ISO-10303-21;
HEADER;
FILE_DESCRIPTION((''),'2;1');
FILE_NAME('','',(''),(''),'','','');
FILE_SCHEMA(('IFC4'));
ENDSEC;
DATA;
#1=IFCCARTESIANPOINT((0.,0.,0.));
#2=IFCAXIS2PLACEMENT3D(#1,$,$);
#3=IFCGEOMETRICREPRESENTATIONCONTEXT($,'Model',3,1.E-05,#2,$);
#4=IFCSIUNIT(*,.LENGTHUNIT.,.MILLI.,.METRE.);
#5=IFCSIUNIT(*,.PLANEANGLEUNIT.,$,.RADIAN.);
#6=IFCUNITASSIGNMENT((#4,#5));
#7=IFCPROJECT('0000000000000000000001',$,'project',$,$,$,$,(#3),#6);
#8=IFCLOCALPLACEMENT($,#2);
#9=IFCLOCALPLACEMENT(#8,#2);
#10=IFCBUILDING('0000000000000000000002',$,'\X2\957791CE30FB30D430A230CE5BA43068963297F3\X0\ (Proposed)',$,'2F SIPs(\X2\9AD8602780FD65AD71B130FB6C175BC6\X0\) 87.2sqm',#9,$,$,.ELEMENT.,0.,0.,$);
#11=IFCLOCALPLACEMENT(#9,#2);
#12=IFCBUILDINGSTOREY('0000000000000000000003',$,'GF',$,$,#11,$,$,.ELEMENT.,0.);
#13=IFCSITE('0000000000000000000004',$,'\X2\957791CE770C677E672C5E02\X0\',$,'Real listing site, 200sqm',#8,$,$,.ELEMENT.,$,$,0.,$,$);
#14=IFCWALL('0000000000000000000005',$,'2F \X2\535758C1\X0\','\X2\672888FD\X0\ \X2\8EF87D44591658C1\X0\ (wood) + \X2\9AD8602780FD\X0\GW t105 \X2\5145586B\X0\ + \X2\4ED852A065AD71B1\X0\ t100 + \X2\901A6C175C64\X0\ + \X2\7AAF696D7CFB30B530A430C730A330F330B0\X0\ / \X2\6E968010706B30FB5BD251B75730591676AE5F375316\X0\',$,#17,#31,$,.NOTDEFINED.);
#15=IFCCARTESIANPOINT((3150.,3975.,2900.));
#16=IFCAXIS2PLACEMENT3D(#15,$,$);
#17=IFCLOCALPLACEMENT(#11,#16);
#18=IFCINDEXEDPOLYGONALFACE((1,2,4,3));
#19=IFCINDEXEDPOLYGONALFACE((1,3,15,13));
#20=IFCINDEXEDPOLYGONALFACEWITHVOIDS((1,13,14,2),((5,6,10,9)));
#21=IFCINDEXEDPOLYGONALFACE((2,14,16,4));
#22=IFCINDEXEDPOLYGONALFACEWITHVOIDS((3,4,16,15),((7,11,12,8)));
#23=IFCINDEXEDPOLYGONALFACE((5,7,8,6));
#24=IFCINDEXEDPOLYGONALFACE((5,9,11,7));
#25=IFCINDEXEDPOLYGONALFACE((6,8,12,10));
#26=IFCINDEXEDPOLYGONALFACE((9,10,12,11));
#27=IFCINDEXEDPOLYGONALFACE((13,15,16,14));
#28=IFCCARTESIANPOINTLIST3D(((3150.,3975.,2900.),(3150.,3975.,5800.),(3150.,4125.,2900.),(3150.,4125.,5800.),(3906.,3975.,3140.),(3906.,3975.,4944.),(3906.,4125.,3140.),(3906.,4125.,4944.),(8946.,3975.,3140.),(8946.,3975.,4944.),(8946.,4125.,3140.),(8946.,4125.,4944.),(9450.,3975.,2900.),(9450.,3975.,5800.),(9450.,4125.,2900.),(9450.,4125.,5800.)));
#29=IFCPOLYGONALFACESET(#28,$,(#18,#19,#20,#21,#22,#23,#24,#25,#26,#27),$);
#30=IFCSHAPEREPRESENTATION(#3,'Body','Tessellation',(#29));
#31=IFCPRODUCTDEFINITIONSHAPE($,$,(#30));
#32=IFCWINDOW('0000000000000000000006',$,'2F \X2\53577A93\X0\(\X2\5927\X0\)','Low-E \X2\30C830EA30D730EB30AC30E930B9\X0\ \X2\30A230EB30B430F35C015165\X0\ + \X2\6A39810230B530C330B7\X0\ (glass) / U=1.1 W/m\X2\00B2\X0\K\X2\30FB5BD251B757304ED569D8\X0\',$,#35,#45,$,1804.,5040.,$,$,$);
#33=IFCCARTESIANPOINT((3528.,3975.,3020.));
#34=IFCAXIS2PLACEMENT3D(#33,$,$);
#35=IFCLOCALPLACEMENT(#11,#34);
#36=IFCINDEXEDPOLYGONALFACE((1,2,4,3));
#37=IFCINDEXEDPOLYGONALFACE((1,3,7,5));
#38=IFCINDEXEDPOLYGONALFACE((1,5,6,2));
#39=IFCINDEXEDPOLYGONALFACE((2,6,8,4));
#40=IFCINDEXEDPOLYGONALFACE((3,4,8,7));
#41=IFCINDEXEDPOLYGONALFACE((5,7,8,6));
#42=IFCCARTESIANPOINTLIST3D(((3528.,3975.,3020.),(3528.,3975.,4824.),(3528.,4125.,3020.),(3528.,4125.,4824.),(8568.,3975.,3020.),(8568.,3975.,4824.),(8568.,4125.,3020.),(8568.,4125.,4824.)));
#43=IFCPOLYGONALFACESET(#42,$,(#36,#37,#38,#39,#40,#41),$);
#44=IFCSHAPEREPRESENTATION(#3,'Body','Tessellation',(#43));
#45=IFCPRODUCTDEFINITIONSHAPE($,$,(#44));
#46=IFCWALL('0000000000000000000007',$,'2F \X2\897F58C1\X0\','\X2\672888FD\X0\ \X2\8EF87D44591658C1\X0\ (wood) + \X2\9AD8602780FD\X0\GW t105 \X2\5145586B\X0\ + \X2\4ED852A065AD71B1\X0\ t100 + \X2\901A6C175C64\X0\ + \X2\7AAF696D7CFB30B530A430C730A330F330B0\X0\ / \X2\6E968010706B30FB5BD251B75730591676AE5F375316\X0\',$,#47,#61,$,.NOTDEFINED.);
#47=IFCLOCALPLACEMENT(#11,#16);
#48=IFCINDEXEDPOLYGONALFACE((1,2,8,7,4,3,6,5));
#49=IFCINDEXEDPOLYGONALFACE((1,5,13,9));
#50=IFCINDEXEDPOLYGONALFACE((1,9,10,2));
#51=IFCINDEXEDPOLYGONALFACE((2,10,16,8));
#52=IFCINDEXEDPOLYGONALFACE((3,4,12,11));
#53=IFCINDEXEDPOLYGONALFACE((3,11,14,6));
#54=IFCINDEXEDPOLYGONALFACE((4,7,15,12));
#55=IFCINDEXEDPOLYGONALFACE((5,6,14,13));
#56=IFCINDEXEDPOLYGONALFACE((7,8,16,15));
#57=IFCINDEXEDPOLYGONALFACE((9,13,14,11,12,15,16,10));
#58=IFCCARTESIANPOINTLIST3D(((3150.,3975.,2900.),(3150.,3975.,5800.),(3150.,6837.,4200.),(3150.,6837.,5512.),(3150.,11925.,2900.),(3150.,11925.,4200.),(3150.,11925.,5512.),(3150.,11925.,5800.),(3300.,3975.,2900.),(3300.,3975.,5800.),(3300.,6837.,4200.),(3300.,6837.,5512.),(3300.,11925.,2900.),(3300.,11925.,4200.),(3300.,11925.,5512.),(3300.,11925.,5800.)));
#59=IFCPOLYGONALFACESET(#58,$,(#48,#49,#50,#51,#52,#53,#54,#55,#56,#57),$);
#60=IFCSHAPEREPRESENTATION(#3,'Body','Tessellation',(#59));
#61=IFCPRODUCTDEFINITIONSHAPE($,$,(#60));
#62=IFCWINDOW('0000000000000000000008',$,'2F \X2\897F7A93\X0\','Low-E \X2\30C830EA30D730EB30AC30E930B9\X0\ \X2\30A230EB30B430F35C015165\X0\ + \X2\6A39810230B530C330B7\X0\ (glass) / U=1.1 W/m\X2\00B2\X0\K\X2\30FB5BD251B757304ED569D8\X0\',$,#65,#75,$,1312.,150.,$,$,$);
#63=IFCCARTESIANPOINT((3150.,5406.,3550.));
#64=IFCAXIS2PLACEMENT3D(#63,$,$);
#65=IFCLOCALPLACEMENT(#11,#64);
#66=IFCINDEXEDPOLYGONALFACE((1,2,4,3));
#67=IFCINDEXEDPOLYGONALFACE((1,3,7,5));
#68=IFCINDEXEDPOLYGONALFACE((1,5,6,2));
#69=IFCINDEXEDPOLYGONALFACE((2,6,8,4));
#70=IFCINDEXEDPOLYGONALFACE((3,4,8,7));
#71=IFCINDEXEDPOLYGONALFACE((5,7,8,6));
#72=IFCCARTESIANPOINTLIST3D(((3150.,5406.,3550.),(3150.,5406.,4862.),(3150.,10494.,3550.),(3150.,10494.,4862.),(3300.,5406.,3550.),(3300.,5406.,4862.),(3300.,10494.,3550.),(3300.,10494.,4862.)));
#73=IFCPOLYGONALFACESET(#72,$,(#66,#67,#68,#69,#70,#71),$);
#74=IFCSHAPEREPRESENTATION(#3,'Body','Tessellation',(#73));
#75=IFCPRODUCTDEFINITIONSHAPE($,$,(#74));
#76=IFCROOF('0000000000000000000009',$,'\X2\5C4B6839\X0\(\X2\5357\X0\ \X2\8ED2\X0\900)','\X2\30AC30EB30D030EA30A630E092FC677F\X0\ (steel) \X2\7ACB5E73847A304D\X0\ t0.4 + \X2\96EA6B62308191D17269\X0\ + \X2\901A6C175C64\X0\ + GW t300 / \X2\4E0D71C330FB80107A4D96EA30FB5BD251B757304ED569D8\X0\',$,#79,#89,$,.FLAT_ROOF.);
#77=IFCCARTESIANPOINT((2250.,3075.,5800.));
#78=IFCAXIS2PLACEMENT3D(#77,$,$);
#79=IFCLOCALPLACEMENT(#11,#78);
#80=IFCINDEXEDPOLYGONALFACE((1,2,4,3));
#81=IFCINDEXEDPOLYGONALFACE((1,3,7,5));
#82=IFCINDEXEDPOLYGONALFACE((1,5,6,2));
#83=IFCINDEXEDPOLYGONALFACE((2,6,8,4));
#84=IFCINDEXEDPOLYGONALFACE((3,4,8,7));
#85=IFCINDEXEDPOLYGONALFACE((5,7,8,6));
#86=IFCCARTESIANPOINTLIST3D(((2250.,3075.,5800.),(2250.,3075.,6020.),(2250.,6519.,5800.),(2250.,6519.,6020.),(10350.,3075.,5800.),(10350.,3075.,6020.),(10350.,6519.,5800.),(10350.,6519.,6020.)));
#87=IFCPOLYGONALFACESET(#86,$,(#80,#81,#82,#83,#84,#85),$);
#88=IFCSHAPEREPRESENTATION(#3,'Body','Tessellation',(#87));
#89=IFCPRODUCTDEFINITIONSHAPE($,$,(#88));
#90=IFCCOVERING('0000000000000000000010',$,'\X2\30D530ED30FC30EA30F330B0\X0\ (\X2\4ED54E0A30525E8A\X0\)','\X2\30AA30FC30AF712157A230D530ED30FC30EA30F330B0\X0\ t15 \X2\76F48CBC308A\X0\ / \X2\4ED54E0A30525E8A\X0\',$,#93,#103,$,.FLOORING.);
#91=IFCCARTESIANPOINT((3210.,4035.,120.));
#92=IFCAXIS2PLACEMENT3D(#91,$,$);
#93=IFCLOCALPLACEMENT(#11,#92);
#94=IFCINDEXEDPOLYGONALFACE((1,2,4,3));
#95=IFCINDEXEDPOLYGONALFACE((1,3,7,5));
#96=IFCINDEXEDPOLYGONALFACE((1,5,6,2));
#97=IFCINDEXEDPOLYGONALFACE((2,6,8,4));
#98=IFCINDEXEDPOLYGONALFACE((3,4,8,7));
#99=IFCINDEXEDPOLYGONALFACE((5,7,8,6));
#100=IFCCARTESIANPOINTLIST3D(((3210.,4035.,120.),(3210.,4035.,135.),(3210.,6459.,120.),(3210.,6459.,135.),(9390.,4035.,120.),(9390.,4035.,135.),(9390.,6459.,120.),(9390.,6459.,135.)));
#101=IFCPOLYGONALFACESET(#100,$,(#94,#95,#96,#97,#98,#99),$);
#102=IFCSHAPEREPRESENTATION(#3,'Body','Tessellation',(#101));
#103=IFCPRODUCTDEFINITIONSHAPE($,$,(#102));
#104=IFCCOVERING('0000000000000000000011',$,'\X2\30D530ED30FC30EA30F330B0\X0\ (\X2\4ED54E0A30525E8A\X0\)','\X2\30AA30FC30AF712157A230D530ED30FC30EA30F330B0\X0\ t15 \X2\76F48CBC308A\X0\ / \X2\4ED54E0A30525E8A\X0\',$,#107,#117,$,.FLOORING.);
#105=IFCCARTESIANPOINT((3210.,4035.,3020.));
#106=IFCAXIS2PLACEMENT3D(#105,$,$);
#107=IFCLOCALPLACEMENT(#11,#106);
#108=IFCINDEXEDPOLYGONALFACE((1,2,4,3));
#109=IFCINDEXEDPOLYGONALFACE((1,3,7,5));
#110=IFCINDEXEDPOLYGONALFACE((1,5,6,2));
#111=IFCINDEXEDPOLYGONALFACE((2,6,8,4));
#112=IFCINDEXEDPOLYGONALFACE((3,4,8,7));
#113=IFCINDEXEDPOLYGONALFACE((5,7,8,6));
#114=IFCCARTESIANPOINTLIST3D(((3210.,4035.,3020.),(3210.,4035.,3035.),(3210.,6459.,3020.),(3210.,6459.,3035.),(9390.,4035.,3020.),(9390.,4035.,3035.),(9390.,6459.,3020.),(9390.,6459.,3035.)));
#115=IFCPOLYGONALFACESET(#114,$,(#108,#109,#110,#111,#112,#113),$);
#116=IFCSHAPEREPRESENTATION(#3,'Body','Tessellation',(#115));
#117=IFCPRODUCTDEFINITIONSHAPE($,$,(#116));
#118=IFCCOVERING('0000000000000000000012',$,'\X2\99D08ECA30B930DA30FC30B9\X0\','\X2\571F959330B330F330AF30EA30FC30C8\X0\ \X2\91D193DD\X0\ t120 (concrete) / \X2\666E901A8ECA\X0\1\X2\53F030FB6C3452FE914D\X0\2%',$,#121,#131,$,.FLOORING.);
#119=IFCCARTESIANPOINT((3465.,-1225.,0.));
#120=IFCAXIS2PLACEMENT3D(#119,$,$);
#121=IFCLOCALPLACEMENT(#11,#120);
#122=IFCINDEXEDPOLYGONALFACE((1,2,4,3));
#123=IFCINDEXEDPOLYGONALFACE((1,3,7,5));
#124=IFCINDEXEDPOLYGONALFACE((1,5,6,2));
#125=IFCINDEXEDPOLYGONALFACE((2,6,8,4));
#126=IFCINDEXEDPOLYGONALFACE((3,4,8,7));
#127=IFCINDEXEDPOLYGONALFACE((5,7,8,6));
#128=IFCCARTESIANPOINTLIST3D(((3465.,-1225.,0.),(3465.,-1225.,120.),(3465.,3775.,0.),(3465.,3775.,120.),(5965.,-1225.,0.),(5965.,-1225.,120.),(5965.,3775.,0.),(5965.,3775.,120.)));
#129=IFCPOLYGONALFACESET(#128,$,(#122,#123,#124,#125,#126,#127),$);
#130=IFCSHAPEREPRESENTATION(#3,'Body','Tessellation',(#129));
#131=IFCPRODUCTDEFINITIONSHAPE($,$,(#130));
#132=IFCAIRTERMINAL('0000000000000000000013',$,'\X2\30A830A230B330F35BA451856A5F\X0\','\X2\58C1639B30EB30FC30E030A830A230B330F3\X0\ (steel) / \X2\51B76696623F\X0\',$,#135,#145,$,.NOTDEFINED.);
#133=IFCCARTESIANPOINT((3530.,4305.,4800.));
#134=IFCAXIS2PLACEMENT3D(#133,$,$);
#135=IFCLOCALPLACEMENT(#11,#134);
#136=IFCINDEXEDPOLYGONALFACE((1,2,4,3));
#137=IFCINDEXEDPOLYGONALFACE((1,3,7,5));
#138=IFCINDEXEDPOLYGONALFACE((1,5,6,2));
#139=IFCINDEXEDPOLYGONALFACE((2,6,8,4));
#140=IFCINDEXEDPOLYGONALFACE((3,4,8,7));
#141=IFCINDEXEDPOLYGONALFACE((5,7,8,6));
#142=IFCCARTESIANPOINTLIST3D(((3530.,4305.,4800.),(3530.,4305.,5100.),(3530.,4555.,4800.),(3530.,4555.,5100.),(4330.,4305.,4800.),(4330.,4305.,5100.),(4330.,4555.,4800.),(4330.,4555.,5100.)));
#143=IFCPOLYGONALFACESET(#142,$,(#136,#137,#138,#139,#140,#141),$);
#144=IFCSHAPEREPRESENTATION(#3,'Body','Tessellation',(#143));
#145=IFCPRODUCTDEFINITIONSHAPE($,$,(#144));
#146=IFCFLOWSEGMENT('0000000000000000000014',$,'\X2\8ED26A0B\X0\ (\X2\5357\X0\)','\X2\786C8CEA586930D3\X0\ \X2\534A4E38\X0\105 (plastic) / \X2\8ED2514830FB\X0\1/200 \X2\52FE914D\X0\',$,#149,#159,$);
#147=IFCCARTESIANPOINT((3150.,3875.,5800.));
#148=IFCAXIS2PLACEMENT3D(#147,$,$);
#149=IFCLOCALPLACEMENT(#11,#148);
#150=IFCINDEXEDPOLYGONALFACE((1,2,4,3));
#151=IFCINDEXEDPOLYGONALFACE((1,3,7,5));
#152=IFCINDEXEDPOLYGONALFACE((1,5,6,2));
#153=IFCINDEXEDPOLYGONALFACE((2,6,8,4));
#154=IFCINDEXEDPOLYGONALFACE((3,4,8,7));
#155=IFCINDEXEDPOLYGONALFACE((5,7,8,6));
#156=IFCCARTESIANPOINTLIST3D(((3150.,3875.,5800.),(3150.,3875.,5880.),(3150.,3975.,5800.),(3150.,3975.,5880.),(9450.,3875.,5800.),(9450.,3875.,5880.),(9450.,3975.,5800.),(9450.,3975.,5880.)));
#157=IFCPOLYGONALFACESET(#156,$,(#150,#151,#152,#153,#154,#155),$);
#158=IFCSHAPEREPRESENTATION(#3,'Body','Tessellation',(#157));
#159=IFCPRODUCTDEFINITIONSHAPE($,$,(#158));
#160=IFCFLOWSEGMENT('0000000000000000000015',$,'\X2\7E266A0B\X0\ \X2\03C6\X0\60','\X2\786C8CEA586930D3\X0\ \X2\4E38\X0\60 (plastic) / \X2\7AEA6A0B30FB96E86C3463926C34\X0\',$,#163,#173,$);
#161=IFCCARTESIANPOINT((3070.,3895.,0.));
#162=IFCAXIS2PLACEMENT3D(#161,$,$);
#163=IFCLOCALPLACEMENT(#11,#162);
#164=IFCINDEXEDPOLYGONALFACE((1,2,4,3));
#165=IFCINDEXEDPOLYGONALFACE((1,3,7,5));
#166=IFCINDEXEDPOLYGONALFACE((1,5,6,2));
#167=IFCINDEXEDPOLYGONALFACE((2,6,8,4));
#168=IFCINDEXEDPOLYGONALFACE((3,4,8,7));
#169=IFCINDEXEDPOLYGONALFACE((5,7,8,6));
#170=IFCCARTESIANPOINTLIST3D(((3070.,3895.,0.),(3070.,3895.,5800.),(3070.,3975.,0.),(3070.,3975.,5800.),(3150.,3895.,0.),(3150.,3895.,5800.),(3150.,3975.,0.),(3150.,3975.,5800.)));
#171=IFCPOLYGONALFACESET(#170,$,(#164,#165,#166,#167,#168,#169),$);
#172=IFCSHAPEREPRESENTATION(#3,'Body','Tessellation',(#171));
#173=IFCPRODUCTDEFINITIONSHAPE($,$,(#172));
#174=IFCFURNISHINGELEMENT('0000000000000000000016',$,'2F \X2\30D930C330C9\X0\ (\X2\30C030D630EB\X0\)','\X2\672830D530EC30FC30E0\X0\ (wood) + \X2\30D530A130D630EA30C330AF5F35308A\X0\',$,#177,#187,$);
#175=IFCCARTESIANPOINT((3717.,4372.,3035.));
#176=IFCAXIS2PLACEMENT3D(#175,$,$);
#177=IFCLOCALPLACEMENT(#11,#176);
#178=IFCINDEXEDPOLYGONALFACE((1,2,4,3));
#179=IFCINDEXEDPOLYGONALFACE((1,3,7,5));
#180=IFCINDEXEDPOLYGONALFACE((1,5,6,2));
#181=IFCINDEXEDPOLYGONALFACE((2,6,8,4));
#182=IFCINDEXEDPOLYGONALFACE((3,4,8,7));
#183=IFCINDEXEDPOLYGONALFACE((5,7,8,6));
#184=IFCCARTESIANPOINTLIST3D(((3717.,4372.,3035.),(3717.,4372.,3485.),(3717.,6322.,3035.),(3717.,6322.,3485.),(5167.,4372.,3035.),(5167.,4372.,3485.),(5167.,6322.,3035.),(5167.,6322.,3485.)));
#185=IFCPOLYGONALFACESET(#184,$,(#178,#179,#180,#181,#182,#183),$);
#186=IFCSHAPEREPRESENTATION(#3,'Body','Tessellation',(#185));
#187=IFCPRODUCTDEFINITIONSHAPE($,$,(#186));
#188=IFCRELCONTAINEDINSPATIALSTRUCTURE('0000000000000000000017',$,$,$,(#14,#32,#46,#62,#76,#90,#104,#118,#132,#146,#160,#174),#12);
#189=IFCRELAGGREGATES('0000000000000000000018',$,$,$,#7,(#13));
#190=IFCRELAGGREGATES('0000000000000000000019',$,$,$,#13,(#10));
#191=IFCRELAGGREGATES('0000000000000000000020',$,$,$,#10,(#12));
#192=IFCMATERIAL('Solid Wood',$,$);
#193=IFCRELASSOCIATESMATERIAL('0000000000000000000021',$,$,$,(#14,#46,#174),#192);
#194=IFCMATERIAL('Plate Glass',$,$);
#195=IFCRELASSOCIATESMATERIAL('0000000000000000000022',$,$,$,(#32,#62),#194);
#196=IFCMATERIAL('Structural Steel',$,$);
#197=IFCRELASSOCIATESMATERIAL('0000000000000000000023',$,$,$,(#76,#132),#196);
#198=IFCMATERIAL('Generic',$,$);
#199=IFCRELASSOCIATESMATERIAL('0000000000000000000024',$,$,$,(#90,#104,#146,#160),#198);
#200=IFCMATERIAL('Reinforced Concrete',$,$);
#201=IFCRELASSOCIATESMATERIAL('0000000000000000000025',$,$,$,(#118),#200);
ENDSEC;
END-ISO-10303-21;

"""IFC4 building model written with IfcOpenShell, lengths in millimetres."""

from ifc_helpers import new_model, si_unit, frame, frame_2d, origin, place, context, project, spatial, rectangle, extrude, material, element, fill, save


model = new_model("IFC4")

# Units and contexts
model_context = context("Model", 3, precision=1e-05, world=origin())
ifc_project = project(units=[si_unit("LENGTHUNIT", "METRE", prefix="MILLI"), si_unit("PLANEANGLEUNIT", "RADIAN")], contexts=[model_context])

# Site, building, storey
site_placement = place(None, origin())
site = spatial("IfcSite", under=ifc_project, at=site_placement, Name="長野県松本市", ObjectType="Real listing site, 200sqm", CompositionType="ELEMENT", RefElevation=0.0)
building_placement = place(site_placement, origin())
building = spatial("IfcBuilding", under=site, at=building_placement, Name="長野・ピアノ室と防音 (Proposed)", ObjectType="2F SIPs(高性能断熱・気密) 87.2sqm", CompositionType="ELEMENT", ElevationOfRefHeight=0.0, ElevationOfTerrain=0.0)
storey_placement = place(building_placement, origin())
storey = spatial("IfcBuildingStorey", under=building, at=storey_placement, Name="GF", CompositionType="ELEMENT", Elevation=0.0)

# Shared definitions
ifc_material_1 = material(Name="Solid Wood")

# Shared definitions
ifc_material_2 = material(Name="Reinforced Concrete")

# Shared definitions
ifc_material_3 = material(Name="Plate Glass")

# Walls, openings, windows
wall_1_placement = place(storey_placement, frame((3150.0, 3975.0, 2900.0)))
wall_1 = element("IfcWall", 1, at=wall_1_placement, inside=storey, material=ifc_material_1, Name="2F 南壁", Description="木製 軸組外壁 (wood) + 高性能GW t105 充填 + 付加断熱 t100 + 通気層 + 窯業系サイディング / 準耐火・寒冷地外皮強化", PredefinedType="NOTDEFINED", context=model_context, shape_type="SweptSolid", body=[
    extrude(rectangle(XDim=6300.0, YDim=150.0, at=frame_2d((3150.0, 75.0))), frame((3150.0, 3975.0, 2900.0)), (0.0, 0.0, 1.0), 2900.0),
])
opening_1_placement = place(storey_placement, frame((3528.0, 3975.0, 3020.0)))
opening_1 = element("IfcOpeningElement", 2, at=opening_1_placement, cuts=wall_1, PredefinedType="NOTDEFINED", context=model_context, shape_type="SweptSolid", body=[
    extrude(rectangle(XDim=5040.0, YDim=150.0, at=frame_2d((2520.0, 75.0))), frame((3528.0, 3975.0, 3020.0)), (0.0, 0.0, 1.0), 1804.0),
])
window_1_placement = place(storey_placement, frame((3528.0, 3975.0, 3020.0)))
window_1 = element("IfcWindow", 3, at=window_1_placement, inside=storey, material=ifc_material_3, Name="2F 南窓(大)", Description="Low-E トリプルガラス アルゴン封入 + 樹脂サッシ (glass) / U=1.1 W/m²K・寒冷地仕様", OverallHeight=1804.0, OverallWidth=5040.0, context=model_context, shape_type="SweptSolid", body=[
    extrude(rectangle(XDim=5040.0, YDim=150.0, at=frame_2d((2520.0, 75.0))), frame((3528.0, 3975.0, 3020.0)), (0.0, 0.0, 1.0), 1804.0),
])
fill(opening_1, window_1)
wall_2_placement = place(storey_placement, frame((3150.0, 3975.0, 2900.0)))
wall_2 = element("IfcWall", 4, at=wall_2_placement, inside=storey, material=ifc_material_1, Name="2F 西壁", Description="木製 軸組外壁 (wood) + 高性能GW t105 充填 + 付加断熱 t100 + 通気層 + 窯業系サイディング / 準耐火・寒冷地外皮強化", PredefinedType="NOTDEFINED", context=model_context, shape_type="SweptSolid", body=[
    extrude(rectangle(XDim=150.0, YDim=7950.0, at=frame_2d((75.0, 3975.0))), frame((3150.0, 3975.0, 2900.0)), (0.0, 0.0, 1.0), 2900.0),
])
opening_2_placement = place(storey_placement, frame((3150.0, 5406.0, 3550.0)))
opening_2 = element("IfcOpeningElement", 5, at=opening_2_placement, cuts=wall_2, PredefinedType="NOTDEFINED", context=model_context, shape_type="SweptSolid", body=[
    extrude(rectangle(XDim=150.0, YDim=5088.0, at=frame_2d((75.0, 2544.0))), frame((3150.0, 5406.0, 3550.0)), (0.0, 0.0, 1.0), 1312.0),
])
window_2_placement = place(storey_placement, frame((3150.0, 5406.0, 3550.0)))
window_2 = element("IfcWindow", 6, at=window_2_placement, inside=storey, material=ifc_material_3, Name="2F 西窓", Description="Low-E トリプルガラス アルゴン封入 + 樹脂サッシ (glass) / U=1.1 W/m²K・寒冷地仕様", OverallHeight=1312.0, OverallWidth=150.0, context=model_context, shape_type="SweptSolid", body=[
    extrude(rectangle(XDim=150.0, YDim=5088.0, at=frame_2d((75.0, 2544.0))), frame((3150.0, 5406.0, 3550.0)), (0.0, 0.0, 1.0), 1312.0),
])
fill(opening_2, window_2)

# Roof
ifc_material_4 = material(Name="Structural Steel")
for number, where, name in (
    (7, (2250.0, 3075.0, 5800.0), "屋根(南 軒900)"),
):
    element("IfcRoof", number, at=place(storey_placement, frame(where)), inside=storey, material=ifc_material_4, Name=name, Description="ガルバリウム鋼板 (steel) 立平葺き t0.4 + 雪止め金物 + 通気層 + GW t300 / 不燃・耐積雪・寒冷地仕様", PredefinedType="FLAT_ROOF", context=model_context, shape_type="SweptSolid", body=[
        extrude(rectangle(XDim=8100.0, YDim=3444.0, at=frame_2d((4050.0, 1722.0))), frame((2250.0, 3075.0, 5800.0)), (0.0, 0.0, 1.0), 220.0),
    ])

# Coverings
ifc_material_5 = material(Name="Generic")
covering_1_placement = place(storey_placement, frame((3210.0, 4035.0, 120.0)))
element("IfcCovering", 8, at=covering_1_placement, inside=storey, material=ifc_material_5, Name="フローリング (仕上げ床)", Description="オーク無垢フローリング t15 直貼り / 仕上げ床", PredefinedType="FLOORING", context=model_context, shape_type="SweptSolid", body=[
    extrude(rectangle(XDim=6180.0, YDim=2424.0, at=frame_2d((3090.0, 1212.0))), frame((3210.0, 4035.0, 120.0)), (0.0, 0.0, 1.0), 15.0),
])
covering_2_placement = place(storey_placement, frame((3210.0, 4035.0, 3020.0)))
element("IfcCovering", 9, at=covering_2_placement, inside=storey, material=ifc_material_5, Name="フローリング (仕上げ床)", Description="オーク無垢フローリング t15 直貼り / 仕上げ床", PredefinedType="FLOORING", context=model_context, shape_type="SweptSolid", body=[
    extrude(rectangle(XDim=6180.0, YDim=2424.0, at=frame_2d((3090.0, 1212.0))), frame((3210.0, 4035.0, 3020.0)), (0.0, 0.0, 1.0), 15.0),
])
covering_3_placement = place(storey_placement, frame((3465.0, -1225.0, 0.0)))
element("IfcCovering", 10, at=covering_3_placement, inside=storey, material=ifc_material_2, Name="駐車スペース", Description="土間コンクリート 金鏝 t120 (concrete) / 普通車1台・水勾配2%", PredefinedType="FLOORING", context=model_context, shape_type="SweptSolid", body=[
    extrude(rectangle(XDim=2500.0, YDim=5000.0, at=frame_2d((1250.0, 2500.0))), frame((3465.0, -1225.0, 0.0)), (0.0, 0.0, 1.0), 120.0),
])

# Air terminal
air_terminal_placement = place(storey_placement, frame((3530.0, 4305.0, 4800.0)))
element("IfcAirTerminal", 11, at=air_terminal_placement, inside=storey, material=ifc_material_4, Name="エアコン室内機", Description="壁掛ルームエアコン (steel) / 冷暖房", PredefinedType="NOTDEFINED", context=model_context, shape_type="SweptSolid", body=[
    extrude(rectangle(XDim=800.0, YDim=250.0, at=frame_2d((400.0, 125.0))), frame((3530.0, 4305.0, 4800.0)), (0.0, 0.0, 1.0), 300.0),
])

# Flow segments
flow_segment_1_placement = place(storey_placement, frame((3150.0, 3875.0, 5800.0)))
element("IfcFlowSegment", 12, at=flow_segment_1_placement, inside=storey, material=ifc_material_5, Name="軒樋 (南)", Description="硬質塩ビ 半丸105 (plastic) / 軒先・1/200 勾配", context=model_context, shape_type="SweptSolid", body=[
    extrude(rectangle(XDim=6300.0, YDim=100.0, at=frame_2d((3150.0, 50.0))), frame((3150.0, 3875.0, 5800.0)), (0.0, 0.0, 1.0), 80.0),
])
flow_segment_2_placement = place(storey_placement, frame((3070.0, 3895.0, 0.0)))
element("IfcFlowSegment", 13, at=flow_segment_2_placement, inside=storey, material=ifc_material_5, Name="縦樋 φ60", Description="硬質塩ビ 丸60 (plastic) / 竪樋・雨水排水", context=model_context, shape_type="SweptSolid", body=[
    extrude(rectangle(XDim=80.0, YDim=80.0, at=frame_2d((40.0, 40.0))), frame((3070.0, 3895.0, 0.0)), (0.0, 0.0, 1.0), 5800.0),
])

# Furnishing element
furnishing_placement = place(storey_placement, frame((3717.0, 4372.0, 3035.0)))
element("IfcFurnishingElement", 14, at=furnishing_placement, inside=storey, material=ifc_material_1, Name="2F ベッド (ダブル)", Description="木フレーム (wood) + ファブリック張り", context=model_context, shape_type="SweptSolid", body=[
    extrude(rectangle(XDim=1450.0, YDim=1950.0, at=frame_2d((725.0, 975.0))), frame((3717.0, 4372.0, 3035.0)), (0.0, 0.0, 1.0), 450.0),
])

save(model, "model.ifc")
